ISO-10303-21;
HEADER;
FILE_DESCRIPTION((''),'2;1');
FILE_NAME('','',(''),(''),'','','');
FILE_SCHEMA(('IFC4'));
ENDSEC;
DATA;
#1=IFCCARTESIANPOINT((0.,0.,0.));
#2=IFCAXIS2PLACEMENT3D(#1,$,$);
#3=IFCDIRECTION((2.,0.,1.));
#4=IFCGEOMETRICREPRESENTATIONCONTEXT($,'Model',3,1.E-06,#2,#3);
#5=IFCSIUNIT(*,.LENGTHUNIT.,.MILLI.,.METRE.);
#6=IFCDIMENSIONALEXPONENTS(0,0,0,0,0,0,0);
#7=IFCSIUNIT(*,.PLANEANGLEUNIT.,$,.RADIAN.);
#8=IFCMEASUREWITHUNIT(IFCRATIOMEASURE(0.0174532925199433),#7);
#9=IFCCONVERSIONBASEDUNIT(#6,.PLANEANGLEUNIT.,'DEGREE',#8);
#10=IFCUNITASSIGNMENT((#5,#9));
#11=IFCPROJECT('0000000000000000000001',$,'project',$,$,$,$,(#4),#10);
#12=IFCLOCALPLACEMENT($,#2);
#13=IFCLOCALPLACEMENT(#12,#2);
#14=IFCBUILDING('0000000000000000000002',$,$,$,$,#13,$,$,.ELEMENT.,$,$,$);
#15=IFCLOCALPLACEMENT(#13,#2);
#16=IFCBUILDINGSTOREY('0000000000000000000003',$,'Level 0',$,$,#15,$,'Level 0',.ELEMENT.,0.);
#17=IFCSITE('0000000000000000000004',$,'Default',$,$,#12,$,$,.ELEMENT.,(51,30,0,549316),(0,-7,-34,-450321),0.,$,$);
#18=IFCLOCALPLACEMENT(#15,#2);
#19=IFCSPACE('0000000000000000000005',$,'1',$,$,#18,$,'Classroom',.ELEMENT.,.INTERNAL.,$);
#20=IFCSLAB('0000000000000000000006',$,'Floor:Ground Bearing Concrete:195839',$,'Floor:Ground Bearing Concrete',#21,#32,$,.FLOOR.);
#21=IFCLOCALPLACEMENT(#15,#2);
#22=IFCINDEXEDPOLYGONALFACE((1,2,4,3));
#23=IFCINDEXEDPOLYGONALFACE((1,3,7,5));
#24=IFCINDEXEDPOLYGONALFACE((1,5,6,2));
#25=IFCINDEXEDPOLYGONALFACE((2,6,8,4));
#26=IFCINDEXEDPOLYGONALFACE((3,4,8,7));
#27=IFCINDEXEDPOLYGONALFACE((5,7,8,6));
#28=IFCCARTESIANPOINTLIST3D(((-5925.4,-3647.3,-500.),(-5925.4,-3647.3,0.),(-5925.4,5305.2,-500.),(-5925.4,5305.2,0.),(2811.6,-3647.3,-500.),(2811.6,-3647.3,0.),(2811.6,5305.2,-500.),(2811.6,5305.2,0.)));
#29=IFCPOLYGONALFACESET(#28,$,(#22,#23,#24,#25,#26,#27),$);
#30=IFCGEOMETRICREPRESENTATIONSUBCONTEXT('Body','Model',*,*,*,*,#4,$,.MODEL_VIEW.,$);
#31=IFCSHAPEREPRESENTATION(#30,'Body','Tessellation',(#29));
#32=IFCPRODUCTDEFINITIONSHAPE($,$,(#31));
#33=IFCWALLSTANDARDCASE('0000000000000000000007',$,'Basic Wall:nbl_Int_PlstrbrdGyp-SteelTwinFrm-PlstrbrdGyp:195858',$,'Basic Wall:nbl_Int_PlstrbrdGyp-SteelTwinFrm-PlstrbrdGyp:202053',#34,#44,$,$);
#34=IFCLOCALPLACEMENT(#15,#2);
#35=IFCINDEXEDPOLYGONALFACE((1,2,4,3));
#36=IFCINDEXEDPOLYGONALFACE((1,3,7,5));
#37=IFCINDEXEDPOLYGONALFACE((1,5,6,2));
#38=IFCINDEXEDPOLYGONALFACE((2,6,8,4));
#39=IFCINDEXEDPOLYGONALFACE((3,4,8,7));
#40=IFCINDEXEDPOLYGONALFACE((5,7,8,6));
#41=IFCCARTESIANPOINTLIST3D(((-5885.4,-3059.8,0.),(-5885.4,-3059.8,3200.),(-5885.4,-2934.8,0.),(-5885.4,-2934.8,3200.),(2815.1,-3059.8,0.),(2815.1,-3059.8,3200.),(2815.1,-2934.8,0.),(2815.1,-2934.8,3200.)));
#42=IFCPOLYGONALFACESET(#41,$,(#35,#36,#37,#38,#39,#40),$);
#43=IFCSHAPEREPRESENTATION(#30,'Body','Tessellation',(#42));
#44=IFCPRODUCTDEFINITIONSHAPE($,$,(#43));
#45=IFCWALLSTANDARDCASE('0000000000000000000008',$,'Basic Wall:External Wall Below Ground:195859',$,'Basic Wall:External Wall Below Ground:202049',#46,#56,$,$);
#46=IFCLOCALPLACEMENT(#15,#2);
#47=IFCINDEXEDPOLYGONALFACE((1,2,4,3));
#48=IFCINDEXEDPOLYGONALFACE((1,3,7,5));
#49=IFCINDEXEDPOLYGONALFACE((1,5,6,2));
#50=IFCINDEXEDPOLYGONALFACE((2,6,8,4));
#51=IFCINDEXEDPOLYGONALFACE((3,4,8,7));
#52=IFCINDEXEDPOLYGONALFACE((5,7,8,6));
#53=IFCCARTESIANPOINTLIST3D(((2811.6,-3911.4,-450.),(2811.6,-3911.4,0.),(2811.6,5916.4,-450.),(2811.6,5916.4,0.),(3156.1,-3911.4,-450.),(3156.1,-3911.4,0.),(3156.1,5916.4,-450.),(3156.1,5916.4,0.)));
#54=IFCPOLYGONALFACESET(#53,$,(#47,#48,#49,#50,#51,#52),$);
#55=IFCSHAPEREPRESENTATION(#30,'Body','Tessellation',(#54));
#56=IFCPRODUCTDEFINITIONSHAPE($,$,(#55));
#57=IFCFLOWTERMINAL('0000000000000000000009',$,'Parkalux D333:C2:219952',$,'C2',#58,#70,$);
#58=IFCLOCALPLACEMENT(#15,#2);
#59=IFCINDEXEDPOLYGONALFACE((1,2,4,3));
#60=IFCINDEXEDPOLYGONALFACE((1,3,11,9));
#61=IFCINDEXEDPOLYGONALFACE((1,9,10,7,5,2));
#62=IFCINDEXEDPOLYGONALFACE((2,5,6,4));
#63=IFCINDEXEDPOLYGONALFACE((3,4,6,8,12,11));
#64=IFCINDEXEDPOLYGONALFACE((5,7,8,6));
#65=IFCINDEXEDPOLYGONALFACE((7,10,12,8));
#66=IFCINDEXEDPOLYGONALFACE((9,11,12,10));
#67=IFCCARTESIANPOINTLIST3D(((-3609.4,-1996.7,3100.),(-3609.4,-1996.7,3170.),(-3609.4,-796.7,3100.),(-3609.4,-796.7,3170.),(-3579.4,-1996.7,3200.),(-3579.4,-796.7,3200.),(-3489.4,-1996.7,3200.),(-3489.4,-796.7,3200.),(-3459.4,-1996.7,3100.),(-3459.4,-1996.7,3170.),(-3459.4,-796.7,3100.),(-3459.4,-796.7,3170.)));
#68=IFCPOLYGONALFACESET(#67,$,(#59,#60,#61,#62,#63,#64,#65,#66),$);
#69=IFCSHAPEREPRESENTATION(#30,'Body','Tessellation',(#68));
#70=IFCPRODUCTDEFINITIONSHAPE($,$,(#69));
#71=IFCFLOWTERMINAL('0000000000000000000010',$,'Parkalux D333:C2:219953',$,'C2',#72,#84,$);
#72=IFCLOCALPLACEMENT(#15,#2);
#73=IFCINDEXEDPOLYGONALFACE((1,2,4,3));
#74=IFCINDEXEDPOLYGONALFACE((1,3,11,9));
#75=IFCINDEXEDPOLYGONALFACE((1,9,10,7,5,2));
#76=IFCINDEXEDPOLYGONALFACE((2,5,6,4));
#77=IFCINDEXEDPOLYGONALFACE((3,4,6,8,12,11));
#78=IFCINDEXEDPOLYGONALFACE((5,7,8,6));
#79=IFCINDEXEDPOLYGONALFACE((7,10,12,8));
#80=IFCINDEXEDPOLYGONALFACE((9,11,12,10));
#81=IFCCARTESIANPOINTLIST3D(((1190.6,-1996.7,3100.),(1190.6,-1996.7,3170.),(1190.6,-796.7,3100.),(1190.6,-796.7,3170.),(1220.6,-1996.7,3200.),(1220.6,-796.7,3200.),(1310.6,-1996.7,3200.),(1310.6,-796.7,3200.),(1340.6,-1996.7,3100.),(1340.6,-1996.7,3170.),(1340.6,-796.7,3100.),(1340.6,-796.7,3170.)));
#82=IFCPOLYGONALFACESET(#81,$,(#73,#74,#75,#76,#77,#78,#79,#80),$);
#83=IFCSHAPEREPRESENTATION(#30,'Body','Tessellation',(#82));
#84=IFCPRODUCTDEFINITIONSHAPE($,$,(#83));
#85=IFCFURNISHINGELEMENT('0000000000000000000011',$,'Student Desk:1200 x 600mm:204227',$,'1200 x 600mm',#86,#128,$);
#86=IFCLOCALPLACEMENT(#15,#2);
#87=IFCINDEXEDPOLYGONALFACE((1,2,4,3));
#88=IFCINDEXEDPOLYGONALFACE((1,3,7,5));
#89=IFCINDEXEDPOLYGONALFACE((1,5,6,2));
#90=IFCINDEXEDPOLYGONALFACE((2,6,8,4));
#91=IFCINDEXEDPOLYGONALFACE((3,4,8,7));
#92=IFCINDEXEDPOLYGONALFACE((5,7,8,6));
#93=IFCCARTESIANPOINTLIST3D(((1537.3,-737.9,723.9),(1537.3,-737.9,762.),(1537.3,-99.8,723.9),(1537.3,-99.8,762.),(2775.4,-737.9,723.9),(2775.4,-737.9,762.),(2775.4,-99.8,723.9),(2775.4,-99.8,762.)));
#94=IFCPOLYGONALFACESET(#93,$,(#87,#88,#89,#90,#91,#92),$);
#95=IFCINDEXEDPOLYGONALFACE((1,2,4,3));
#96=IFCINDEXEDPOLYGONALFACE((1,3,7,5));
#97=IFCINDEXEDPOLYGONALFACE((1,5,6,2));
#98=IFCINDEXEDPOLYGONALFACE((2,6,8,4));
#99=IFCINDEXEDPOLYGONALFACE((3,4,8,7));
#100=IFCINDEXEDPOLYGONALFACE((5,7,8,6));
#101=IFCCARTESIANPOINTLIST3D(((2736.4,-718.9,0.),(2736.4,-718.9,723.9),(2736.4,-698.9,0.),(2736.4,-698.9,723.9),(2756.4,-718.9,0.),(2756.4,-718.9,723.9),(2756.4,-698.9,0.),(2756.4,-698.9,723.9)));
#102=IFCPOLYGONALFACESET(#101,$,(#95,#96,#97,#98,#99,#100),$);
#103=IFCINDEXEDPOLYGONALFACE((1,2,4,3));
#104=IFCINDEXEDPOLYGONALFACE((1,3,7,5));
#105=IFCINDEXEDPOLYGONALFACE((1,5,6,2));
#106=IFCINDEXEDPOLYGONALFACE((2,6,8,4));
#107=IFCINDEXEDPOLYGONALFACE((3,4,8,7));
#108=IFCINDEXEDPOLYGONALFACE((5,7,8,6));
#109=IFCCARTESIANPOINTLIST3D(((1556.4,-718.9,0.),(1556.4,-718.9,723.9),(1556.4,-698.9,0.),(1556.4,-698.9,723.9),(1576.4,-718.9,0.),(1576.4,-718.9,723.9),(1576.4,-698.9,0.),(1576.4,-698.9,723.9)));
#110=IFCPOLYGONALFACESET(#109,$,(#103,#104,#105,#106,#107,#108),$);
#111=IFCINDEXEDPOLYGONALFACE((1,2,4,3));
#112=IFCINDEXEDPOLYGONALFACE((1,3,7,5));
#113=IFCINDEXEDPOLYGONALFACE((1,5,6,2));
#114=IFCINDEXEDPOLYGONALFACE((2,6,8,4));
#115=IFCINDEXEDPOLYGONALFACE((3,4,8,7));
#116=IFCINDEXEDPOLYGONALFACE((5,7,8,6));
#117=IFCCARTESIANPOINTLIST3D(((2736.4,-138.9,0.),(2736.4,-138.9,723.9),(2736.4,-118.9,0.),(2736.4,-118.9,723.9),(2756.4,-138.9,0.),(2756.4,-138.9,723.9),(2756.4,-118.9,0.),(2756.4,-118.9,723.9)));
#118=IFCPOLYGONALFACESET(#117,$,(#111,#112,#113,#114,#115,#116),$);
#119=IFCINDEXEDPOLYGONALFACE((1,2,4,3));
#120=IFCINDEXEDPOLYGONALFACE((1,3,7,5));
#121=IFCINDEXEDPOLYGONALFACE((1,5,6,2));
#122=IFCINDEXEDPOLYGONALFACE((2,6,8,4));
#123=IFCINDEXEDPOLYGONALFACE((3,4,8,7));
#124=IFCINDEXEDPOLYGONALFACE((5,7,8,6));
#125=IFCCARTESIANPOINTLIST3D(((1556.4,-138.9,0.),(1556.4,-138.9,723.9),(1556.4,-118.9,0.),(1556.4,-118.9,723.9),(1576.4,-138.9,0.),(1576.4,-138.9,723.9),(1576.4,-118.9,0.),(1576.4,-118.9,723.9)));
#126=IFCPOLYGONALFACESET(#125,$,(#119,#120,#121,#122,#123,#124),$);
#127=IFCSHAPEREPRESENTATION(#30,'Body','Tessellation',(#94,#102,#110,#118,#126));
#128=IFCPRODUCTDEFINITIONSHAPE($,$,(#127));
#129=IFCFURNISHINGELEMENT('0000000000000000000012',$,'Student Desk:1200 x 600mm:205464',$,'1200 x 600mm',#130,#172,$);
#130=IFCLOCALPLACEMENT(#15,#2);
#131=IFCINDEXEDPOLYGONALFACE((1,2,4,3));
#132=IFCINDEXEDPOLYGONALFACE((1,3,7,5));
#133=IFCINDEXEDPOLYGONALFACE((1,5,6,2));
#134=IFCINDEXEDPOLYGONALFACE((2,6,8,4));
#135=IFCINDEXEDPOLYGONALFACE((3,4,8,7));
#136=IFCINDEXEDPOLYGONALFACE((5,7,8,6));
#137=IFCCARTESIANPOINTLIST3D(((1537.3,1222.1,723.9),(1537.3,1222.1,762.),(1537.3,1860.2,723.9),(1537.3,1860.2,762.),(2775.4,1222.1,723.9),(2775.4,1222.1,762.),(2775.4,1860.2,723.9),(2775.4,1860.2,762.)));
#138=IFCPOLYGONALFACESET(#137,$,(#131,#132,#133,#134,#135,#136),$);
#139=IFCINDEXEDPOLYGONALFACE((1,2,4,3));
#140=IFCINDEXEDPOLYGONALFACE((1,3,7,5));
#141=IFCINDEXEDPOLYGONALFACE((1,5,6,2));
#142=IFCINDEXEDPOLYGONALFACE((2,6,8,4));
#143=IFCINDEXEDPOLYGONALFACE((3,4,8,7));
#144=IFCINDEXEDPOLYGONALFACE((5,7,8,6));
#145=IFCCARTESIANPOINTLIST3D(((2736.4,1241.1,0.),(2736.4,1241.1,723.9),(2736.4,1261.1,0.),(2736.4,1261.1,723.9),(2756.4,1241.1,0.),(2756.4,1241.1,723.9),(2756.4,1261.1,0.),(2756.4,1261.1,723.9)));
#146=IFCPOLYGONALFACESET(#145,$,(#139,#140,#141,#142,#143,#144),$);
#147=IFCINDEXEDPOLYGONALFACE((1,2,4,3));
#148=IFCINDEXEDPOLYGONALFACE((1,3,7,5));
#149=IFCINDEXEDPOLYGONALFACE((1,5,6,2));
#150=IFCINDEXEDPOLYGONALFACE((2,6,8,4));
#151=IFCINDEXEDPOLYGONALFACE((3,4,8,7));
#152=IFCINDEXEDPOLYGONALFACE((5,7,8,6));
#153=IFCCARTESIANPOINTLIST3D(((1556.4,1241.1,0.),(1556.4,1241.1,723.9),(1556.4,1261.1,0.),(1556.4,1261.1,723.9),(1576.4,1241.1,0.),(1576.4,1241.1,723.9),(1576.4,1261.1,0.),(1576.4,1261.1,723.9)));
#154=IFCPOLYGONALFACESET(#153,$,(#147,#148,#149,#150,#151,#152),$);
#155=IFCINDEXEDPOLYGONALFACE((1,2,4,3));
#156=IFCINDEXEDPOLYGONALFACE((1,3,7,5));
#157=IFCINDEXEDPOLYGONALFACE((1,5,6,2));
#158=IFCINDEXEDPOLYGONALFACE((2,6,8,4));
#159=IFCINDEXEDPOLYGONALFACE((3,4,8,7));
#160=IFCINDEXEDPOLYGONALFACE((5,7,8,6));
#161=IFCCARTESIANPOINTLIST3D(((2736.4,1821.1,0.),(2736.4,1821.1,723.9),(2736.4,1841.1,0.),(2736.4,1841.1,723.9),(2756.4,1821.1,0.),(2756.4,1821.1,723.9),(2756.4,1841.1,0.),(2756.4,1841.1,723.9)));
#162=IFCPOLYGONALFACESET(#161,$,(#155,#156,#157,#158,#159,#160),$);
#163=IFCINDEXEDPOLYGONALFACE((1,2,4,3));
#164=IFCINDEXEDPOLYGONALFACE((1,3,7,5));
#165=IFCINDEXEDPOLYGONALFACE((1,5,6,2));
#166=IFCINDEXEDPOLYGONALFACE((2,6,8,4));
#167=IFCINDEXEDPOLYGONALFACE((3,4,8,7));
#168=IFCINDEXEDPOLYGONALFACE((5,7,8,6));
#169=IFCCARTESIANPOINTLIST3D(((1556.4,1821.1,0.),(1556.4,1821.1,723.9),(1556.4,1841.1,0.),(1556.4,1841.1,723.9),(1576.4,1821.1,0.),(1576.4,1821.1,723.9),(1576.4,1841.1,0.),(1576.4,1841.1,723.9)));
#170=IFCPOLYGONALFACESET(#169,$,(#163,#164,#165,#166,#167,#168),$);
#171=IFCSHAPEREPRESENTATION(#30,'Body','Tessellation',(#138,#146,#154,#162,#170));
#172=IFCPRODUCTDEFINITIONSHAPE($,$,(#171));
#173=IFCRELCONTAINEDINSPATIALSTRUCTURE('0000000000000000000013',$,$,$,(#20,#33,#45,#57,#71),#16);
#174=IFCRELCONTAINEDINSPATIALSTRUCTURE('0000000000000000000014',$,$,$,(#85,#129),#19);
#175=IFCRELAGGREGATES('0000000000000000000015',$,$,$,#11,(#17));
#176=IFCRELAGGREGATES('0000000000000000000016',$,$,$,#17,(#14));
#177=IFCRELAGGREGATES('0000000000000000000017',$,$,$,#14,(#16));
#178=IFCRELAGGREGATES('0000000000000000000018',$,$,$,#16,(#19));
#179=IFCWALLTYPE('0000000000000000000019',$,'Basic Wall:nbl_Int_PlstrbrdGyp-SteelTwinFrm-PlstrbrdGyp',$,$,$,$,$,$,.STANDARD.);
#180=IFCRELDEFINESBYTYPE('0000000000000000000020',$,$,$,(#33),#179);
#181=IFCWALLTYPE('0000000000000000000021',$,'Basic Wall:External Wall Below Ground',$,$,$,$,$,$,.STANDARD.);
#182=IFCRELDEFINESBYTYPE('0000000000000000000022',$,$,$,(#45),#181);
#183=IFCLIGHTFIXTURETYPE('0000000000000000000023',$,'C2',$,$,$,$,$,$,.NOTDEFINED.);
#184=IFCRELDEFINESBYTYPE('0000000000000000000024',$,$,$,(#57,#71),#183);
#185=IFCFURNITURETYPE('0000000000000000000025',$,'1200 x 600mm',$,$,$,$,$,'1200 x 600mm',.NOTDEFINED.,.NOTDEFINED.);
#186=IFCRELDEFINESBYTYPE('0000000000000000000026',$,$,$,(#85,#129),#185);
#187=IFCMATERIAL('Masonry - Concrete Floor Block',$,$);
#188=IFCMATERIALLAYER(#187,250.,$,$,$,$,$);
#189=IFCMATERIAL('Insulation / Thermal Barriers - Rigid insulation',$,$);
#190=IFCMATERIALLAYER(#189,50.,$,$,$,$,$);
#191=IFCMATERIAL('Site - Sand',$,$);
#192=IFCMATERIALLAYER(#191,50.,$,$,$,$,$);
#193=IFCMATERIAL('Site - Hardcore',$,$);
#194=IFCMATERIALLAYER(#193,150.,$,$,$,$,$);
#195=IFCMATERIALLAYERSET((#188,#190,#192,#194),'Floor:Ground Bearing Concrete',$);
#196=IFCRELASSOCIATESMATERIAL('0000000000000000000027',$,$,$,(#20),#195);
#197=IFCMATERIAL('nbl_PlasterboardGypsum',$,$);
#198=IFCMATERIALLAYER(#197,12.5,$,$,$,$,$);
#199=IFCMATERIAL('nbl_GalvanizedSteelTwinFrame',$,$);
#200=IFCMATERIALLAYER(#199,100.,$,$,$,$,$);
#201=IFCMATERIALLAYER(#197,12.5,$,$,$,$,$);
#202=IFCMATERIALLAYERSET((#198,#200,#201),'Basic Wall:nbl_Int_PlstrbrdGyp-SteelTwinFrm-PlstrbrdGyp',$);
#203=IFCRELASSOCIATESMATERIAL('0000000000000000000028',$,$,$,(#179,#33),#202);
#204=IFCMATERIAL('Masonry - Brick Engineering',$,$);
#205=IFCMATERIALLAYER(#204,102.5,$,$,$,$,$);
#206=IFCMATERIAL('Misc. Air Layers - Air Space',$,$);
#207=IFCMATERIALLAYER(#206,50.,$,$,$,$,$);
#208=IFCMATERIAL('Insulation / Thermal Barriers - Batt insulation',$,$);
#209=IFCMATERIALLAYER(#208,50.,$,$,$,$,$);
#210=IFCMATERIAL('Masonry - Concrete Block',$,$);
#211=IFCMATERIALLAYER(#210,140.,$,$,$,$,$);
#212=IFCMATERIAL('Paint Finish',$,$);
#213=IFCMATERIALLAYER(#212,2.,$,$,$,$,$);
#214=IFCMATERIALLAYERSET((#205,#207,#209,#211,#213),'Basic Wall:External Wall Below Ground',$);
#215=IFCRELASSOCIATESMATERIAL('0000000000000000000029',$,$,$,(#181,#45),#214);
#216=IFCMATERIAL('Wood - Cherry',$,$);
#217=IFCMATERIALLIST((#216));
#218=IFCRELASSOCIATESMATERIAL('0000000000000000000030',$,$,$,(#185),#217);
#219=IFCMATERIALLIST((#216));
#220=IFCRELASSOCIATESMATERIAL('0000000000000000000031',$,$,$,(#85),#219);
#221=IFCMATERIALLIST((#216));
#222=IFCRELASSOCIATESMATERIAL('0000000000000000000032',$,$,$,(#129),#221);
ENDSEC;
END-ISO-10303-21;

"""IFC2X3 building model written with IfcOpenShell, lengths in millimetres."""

from ifc_helpers import new_model, entity, si_unit, converted_unit, direction, frame, frame_2d, origin, origin_2d_with_axis, place, context, subcontext, project, spatial, polyline, rectangle, outline, extrude, clip, bounded_halfspace, source, transform, mapped, material, material_list, layer, layer_set, layer_usage, type_object, type_shapes, element, save


model = new_model("IFC2X3")

# Units and contexts
model_context = context("Model", 3, precision=1e-06, world=origin(), true_north=direction((2.0, 0.0, 1.0)))
body_context = subcontext(model_context, "Body", "Model", "MODEL_VIEW")
ifc_project = project(units=[si_unit("LENGTHUNIT", "METRE", prefix="MILLI"), converted_unit("PLANEANGLEUNIT", "DEGREE", entity("IfcRatioMeasure", 0.0174532925199433), si_unit("PLANEANGLEUNIT", "RADIAN"), dimensions=[0, 0, 0, 0, 0, 0, 0])], contexts=[model_context])

# Site, building, storey
site_placement = place(None, origin())
site = spatial("IfcSite", under=ifc_project, at=site_placement, Name="Default", CompositionType="ELEMENT", RefLatitude=(51, 30, 0, 549316), RefLongitude=(0, -7, -34, -450321), RefElevation=0.0)
building_placement = place(site_placement, origin())
building = spatial("IfcBuilding", under=site, at=building_placement, CompositionType="ELEMENT")
storey_placement = place(building_placement, origin())
storey = spatial("IfcBuildingStorey", under=building, at=storey_placement, Name="Level 0", LongName="Level 0", CompositionType="ELEMENT", Elevation=0.0)

# Slab
ifc_material_1 = material(Name="Masonry - Concrete Floor Block")
ifc_layer_1 = layer(ifc_material_1, 250.0)
ifc_material_2 = material(Name="Insulation / Thermal Barriers - Rigid insulation")
ifc_layer_2 = layer(ifc_material_2, 50.0)
ifc_material_3 = material(Name="Site - Sand")
ifc_layer_3 = layer(ifc_material_3, 50.0)
ifc_material_4 = material(Name="Site - Hardcore")
ifc_layer_4 = layer(ifc_material_4, 150.0)
ifc_layer_set_1 = layer_set([ifc_layer_1, ifc_layer_2, ifc_layer_3, ifc_layer_4], Name="Floor:Ground Bearing Concrete")
ifc_layer_usage_1 = layer_usage(ifc_layer_set_1, "AXIS3", "POSITIVE", 0.0)
slab_placement = place(storey_placement, origin())
element("IfcSlab", 1, at=slab_placement, inside=storey, material=ifc_layer_usage_1, Name="Floor:Ground Bearing Concrete:195839", ObjectType="Floor:Ground Bearing Concrete", PredefinedType="FLOOR", context=body_context, shape_type="SweptSolid", body=[
    extrude(rectangle(XDim=8952.5, YDim=8737.0, at=origin_2d_with_axis()), frame((-1556.9, 829.0, 0.0), z_axis=(0.0, 0.0, -1.0), x_axis=(0.0, 1.0, 0.0)), (0.0, 0.0, 1.0), 500.0),
])

# Walls
ifc_material_5 = material(Name="nbl_PlasterboardGypsum")
ifc_layer_5 = layer(ifc_material_5, 12.5)
ifc_material_6 = material(Name="nbl_GalvanizedSteelTwinFrame")
ifc_layer_6 = layer(ifc_material_6, 100.0)
ifc_layer_7 = layer(ifc_material_5, 12.5)
ifc_layer_set_2 = layer_set([ifc_layer_5, ifc_layer_6, ifc_layer_7], Name="Basic Wall:nbl_Int_PlstrbrdGyp-SteelTwinFrm-PlstrbrdGyp")
ifc_layer_usage_2 = layer_usage(ifc_layer_set_2, "AXIS2", "POSITIVE", -62.5)
wall_type_1 = type_object("IfcWallType", Name="Basic Wall:nbl_Int_PlstrbrdGyp-SteelTwinFrm-PlstrbrdGyp", PredefinedType="STANDARD", material=ifc_layer_set_2)
wall_1_placement = place(storey_placement, frame((-5885.4, -2997.3, 0.0)))
element("IfcWallStandardCase", 2, at=wall_1_placement, inside=storey, type_object=wall_type_1, material=ifc_layer_usage_2, Name="Basic Wall:nbl_Int_PlstrbrdGyp-SteelTwinFrm-PlstrbrdGyp:195858", ObjectType="Basic Wall:nbl_Int_PlstrbrdGyp-SteelTwinFrm-PlstrbrdGyp:202053", context=body_context, shape_type="Clipping", body=[
    clip(extrude(rectangle(XDim=8700.5, YDim=125.0, at=frame_2d((4350.3, 0.0), x_axis=(-1.0, 0.0))), origin(), (0.0, 0.0, 1.0), 3200.0), bounded_halfspace(frame((0.0, -62.5, 3200.0), z_axis=(0.0, 0.0, -1.0), x_axis=(0.0, -1.0, 0.0)), True, frame((0.0, -62.5, 3200.0)), polyline([(0.0, 0.0), (8700.5, 0.0), (8700.5, 125.0), (901.0, 125.0), (776.0, 125.0), (0.0, 125.0), (0.0, 0.0)]))),
])
ifc_material_7 = material(Name="Masonry - Brick Engineering")
ifc_layer_8 = layer(ifc_material_7, 102.5)
ifc_material_8 = material(Name="Misc. Air Layers - Air Space")
ifc_layer_9 = layer(ifc_material_8, 50.0)
ifc_material_9 = material(Name="Insulation / Thermal Barriers - Batt insulation")
ifc_layer_10 = layer(ifc_material_9, 50.0)
ifc_material_10 = material(Name="Masonry - Concrete Block")
ifc_layer_11 = layer(ifc_material_10, 140.0)
ifc_material_11 = material(Name="Paint Finish")
ifc_layer_12 = layer(ifc_material_11, 2.0)
ifc_layer_set_3 = layer_set([ifc_layer_8, ifc_layer_9, ifc_layer_10, ifc_layer_11, ifc_layer_12], Name="Basic Wall:External Wall Below Ground")
ifc_layer_usage_3 = layer_usage(ifc_layer_set_3, "AXIS2", "POSITIVE", -172.2)
wall_type_2 = type_object("IfcWallType", Name="Basic Wall:External Wall Below Ground", PredefinedType="STANDARD", material=ifc_layer_set_3)
wall_2_placement = place(storey_placement, frame((2983.9, -3911.4, -450.0), z_axis=(0.0, 0.0, 1.0), x_axis=(0.0, 1.0, 0.0)))
element("IfcWallStandardCase", 3, at=wall_2_placement, inside=storey, type_object=wall_type_2, material=ifc_layer_usage_3, Name="Basic Wall:External Wall Below Ground:195859", ObjectType="Basic Wall:External Wall Below Ground:202049", context=body_context, shape_type="SweptSolid", body=[
    extrude(rectangle(XDim=9827.8, YDim=344.5, at=frame_2d((4913.9, 0.0), x_axis=(-1.0, 0.0))), origin(), (0.0, 0.0, 1.0), 450.0),
])

# Flow terminals
light_fixture_type = type_object("IfcLightFixtureType", Name="C2", PredefinedType="NOTDEFINED")
shared_shape_1 = source(origin(), body_context, "Body", "SweptSolid", [
    extrude(outline(polyline([(-56.7, -75.0), (13.3, -75.0), (43.3, -45.0), (43.3, 45.0), (13.3, 75.0), (-56.7, 75.0), (-56.7, -75.0)])), frame((0.0, 75.0, 56.7), z_axis=(1.0, 0.0, 0.0), x_axis=(0.0, 0.0, 1.0)), (0.0, 0.0, 1.0), 1200.0),
])
type_shapes(light_fixture_type, [shared_shape_1])
for number, where, z_axis, x_axis, name in (
    (4, (-3609.4, -796.7, 3100.0), (0.0, 0.0, 1.0), (0.0, -1.0, 0.0), "Parkalux D333:C2:219952"),
    (5, (1190.6, -796.7, 3100.0), (0.0, 0.0, 1.0), (0.0, -1.0, 0.0), "Parkalux D333:C2:219953"),
):
    element("IfcFlowTerminal", number, at=place(storey_placement, frame(where, z_axis=z_axis, x_axis=x_axis)), inside=storey, type_object=light_fixture_type, Name=name, ObjectType="C2", context=body_context, shape_type="MappedRepresentation", body=[
        mapped(shared_shape_1, transform((0.0, 0.0, 0.0), scale=1.0)),
    ])

# Shared definitions
space_placement = place(storey_placement, origin())
space = spatial("IfcSpace", under=storey, at=space_placement, Name="1", LongName="Classroom", CompositionType="ELEMENT", InteriorOrExteriorSpace="INTERNAL")

# Furnishing elements
ifc_material_12 = material(Name="Wood - Cherry")
ifc_material_list_1 = material_list([ifc_material_12])
ifc_material_list_2 = material_list([ifc_material_12])
furniture_type = type_object("IfcFurnitureType", Name="1200 x 600mm", ElementType="1200 x 600mm", AssemblyPlace="NOTDEFINED", material=ifc_material_list_2)
shared_shape_2 = source(origin(), body_context, "Body", "SweptSolid", [
    extrude(rectangle(XDim=1238.1, YDim=638.1, at=origin_2d_with_axis()), frame((600.0, 300.0, 723.9), z_axis=(0.0, 0.0, 1.0), x_axis=(-1.0, 0.0, 0.0)), (0.0, 0.0, 1.0), 38.1),
    extrude(rectangle(XDim=20.0, YDim=20.0, at=origin_2d_with_axis()), frame((1190.0, 10.0, 0.0)), (0.0, 0.0, 1.0), 723.9),
    extrude(rectangle(XDim=20.0, YDim=20.0, at=frame_2d((0.0, 0.0), x_axis=(1.0, 0.0))), frame((10.0, 10.0, 0.0), z_axis=(0.0, 0.0, 1.0), x_axis=(0.0, 1.0, 0.0)), (0.0, 0.0, 1.0), 723.9),
    extrude(rectangle(XDim=20.0, YDim=20.0, at=frame_2d((0.0, 0.0), x_axis=(1.0, 0.0))), frame((1190.0, 590.0, 0.0), z_axis=(0.0, 0.0, 1.0), x_axis=(0.0, -1.0, 0.0)), (0.0, 0.0, 1.0), 723.9),
    extrude(rectangle(XDim=20.0, YDim=20.0, at=origin_2d_with_axis()), frame((10.0, 590.0, 0.0), z_axis=(0.0, 0.0, 1.0), x_axis=(-1.0, 0.0, 0.0)), (0.0, 0.0, 1.0), 723.9),
])
type_shapes(furniture_type, [shared_shape_2])
furnishing_1_placement = place(space_placement, frame((1556.4, -718.9, 0.0)))
element("IfcFurnishingElement", 6, at=furnishing_1_placement, inside=space, type_object=furniture_type, material=ifc_material_list_1, Name="Student Desk:1200 x 600mm:204227", ObjectType="1200 x 600mm", context=body_context, shape_type="MappedRepresentation", body=[
    mapped(shared_shape_2, transform((0.0, 0.0, 0.0), scale=1.0)),
])
ifc_material_list_3 = material_list([ifc_material_12])
furnishing_2_placement = place(space_placement, frame((1556.4, 1241.1, 0.0)))
element("IfcFurnishingElement", 7, at=furnishing_2_placement, inside=space, type_object=furniture_type, material=ifc_material_list_3, Name="Student Desk:1200 x 600mm:205464", ObjectType="1200 x 600mm", context=body_context, shape_type="MappedRepresentation", body=[
    mapped(shared_shape_2, transform((0.0, 0.0, 0.0), scale=1.0)),
])

save(model, "model.ifc")
